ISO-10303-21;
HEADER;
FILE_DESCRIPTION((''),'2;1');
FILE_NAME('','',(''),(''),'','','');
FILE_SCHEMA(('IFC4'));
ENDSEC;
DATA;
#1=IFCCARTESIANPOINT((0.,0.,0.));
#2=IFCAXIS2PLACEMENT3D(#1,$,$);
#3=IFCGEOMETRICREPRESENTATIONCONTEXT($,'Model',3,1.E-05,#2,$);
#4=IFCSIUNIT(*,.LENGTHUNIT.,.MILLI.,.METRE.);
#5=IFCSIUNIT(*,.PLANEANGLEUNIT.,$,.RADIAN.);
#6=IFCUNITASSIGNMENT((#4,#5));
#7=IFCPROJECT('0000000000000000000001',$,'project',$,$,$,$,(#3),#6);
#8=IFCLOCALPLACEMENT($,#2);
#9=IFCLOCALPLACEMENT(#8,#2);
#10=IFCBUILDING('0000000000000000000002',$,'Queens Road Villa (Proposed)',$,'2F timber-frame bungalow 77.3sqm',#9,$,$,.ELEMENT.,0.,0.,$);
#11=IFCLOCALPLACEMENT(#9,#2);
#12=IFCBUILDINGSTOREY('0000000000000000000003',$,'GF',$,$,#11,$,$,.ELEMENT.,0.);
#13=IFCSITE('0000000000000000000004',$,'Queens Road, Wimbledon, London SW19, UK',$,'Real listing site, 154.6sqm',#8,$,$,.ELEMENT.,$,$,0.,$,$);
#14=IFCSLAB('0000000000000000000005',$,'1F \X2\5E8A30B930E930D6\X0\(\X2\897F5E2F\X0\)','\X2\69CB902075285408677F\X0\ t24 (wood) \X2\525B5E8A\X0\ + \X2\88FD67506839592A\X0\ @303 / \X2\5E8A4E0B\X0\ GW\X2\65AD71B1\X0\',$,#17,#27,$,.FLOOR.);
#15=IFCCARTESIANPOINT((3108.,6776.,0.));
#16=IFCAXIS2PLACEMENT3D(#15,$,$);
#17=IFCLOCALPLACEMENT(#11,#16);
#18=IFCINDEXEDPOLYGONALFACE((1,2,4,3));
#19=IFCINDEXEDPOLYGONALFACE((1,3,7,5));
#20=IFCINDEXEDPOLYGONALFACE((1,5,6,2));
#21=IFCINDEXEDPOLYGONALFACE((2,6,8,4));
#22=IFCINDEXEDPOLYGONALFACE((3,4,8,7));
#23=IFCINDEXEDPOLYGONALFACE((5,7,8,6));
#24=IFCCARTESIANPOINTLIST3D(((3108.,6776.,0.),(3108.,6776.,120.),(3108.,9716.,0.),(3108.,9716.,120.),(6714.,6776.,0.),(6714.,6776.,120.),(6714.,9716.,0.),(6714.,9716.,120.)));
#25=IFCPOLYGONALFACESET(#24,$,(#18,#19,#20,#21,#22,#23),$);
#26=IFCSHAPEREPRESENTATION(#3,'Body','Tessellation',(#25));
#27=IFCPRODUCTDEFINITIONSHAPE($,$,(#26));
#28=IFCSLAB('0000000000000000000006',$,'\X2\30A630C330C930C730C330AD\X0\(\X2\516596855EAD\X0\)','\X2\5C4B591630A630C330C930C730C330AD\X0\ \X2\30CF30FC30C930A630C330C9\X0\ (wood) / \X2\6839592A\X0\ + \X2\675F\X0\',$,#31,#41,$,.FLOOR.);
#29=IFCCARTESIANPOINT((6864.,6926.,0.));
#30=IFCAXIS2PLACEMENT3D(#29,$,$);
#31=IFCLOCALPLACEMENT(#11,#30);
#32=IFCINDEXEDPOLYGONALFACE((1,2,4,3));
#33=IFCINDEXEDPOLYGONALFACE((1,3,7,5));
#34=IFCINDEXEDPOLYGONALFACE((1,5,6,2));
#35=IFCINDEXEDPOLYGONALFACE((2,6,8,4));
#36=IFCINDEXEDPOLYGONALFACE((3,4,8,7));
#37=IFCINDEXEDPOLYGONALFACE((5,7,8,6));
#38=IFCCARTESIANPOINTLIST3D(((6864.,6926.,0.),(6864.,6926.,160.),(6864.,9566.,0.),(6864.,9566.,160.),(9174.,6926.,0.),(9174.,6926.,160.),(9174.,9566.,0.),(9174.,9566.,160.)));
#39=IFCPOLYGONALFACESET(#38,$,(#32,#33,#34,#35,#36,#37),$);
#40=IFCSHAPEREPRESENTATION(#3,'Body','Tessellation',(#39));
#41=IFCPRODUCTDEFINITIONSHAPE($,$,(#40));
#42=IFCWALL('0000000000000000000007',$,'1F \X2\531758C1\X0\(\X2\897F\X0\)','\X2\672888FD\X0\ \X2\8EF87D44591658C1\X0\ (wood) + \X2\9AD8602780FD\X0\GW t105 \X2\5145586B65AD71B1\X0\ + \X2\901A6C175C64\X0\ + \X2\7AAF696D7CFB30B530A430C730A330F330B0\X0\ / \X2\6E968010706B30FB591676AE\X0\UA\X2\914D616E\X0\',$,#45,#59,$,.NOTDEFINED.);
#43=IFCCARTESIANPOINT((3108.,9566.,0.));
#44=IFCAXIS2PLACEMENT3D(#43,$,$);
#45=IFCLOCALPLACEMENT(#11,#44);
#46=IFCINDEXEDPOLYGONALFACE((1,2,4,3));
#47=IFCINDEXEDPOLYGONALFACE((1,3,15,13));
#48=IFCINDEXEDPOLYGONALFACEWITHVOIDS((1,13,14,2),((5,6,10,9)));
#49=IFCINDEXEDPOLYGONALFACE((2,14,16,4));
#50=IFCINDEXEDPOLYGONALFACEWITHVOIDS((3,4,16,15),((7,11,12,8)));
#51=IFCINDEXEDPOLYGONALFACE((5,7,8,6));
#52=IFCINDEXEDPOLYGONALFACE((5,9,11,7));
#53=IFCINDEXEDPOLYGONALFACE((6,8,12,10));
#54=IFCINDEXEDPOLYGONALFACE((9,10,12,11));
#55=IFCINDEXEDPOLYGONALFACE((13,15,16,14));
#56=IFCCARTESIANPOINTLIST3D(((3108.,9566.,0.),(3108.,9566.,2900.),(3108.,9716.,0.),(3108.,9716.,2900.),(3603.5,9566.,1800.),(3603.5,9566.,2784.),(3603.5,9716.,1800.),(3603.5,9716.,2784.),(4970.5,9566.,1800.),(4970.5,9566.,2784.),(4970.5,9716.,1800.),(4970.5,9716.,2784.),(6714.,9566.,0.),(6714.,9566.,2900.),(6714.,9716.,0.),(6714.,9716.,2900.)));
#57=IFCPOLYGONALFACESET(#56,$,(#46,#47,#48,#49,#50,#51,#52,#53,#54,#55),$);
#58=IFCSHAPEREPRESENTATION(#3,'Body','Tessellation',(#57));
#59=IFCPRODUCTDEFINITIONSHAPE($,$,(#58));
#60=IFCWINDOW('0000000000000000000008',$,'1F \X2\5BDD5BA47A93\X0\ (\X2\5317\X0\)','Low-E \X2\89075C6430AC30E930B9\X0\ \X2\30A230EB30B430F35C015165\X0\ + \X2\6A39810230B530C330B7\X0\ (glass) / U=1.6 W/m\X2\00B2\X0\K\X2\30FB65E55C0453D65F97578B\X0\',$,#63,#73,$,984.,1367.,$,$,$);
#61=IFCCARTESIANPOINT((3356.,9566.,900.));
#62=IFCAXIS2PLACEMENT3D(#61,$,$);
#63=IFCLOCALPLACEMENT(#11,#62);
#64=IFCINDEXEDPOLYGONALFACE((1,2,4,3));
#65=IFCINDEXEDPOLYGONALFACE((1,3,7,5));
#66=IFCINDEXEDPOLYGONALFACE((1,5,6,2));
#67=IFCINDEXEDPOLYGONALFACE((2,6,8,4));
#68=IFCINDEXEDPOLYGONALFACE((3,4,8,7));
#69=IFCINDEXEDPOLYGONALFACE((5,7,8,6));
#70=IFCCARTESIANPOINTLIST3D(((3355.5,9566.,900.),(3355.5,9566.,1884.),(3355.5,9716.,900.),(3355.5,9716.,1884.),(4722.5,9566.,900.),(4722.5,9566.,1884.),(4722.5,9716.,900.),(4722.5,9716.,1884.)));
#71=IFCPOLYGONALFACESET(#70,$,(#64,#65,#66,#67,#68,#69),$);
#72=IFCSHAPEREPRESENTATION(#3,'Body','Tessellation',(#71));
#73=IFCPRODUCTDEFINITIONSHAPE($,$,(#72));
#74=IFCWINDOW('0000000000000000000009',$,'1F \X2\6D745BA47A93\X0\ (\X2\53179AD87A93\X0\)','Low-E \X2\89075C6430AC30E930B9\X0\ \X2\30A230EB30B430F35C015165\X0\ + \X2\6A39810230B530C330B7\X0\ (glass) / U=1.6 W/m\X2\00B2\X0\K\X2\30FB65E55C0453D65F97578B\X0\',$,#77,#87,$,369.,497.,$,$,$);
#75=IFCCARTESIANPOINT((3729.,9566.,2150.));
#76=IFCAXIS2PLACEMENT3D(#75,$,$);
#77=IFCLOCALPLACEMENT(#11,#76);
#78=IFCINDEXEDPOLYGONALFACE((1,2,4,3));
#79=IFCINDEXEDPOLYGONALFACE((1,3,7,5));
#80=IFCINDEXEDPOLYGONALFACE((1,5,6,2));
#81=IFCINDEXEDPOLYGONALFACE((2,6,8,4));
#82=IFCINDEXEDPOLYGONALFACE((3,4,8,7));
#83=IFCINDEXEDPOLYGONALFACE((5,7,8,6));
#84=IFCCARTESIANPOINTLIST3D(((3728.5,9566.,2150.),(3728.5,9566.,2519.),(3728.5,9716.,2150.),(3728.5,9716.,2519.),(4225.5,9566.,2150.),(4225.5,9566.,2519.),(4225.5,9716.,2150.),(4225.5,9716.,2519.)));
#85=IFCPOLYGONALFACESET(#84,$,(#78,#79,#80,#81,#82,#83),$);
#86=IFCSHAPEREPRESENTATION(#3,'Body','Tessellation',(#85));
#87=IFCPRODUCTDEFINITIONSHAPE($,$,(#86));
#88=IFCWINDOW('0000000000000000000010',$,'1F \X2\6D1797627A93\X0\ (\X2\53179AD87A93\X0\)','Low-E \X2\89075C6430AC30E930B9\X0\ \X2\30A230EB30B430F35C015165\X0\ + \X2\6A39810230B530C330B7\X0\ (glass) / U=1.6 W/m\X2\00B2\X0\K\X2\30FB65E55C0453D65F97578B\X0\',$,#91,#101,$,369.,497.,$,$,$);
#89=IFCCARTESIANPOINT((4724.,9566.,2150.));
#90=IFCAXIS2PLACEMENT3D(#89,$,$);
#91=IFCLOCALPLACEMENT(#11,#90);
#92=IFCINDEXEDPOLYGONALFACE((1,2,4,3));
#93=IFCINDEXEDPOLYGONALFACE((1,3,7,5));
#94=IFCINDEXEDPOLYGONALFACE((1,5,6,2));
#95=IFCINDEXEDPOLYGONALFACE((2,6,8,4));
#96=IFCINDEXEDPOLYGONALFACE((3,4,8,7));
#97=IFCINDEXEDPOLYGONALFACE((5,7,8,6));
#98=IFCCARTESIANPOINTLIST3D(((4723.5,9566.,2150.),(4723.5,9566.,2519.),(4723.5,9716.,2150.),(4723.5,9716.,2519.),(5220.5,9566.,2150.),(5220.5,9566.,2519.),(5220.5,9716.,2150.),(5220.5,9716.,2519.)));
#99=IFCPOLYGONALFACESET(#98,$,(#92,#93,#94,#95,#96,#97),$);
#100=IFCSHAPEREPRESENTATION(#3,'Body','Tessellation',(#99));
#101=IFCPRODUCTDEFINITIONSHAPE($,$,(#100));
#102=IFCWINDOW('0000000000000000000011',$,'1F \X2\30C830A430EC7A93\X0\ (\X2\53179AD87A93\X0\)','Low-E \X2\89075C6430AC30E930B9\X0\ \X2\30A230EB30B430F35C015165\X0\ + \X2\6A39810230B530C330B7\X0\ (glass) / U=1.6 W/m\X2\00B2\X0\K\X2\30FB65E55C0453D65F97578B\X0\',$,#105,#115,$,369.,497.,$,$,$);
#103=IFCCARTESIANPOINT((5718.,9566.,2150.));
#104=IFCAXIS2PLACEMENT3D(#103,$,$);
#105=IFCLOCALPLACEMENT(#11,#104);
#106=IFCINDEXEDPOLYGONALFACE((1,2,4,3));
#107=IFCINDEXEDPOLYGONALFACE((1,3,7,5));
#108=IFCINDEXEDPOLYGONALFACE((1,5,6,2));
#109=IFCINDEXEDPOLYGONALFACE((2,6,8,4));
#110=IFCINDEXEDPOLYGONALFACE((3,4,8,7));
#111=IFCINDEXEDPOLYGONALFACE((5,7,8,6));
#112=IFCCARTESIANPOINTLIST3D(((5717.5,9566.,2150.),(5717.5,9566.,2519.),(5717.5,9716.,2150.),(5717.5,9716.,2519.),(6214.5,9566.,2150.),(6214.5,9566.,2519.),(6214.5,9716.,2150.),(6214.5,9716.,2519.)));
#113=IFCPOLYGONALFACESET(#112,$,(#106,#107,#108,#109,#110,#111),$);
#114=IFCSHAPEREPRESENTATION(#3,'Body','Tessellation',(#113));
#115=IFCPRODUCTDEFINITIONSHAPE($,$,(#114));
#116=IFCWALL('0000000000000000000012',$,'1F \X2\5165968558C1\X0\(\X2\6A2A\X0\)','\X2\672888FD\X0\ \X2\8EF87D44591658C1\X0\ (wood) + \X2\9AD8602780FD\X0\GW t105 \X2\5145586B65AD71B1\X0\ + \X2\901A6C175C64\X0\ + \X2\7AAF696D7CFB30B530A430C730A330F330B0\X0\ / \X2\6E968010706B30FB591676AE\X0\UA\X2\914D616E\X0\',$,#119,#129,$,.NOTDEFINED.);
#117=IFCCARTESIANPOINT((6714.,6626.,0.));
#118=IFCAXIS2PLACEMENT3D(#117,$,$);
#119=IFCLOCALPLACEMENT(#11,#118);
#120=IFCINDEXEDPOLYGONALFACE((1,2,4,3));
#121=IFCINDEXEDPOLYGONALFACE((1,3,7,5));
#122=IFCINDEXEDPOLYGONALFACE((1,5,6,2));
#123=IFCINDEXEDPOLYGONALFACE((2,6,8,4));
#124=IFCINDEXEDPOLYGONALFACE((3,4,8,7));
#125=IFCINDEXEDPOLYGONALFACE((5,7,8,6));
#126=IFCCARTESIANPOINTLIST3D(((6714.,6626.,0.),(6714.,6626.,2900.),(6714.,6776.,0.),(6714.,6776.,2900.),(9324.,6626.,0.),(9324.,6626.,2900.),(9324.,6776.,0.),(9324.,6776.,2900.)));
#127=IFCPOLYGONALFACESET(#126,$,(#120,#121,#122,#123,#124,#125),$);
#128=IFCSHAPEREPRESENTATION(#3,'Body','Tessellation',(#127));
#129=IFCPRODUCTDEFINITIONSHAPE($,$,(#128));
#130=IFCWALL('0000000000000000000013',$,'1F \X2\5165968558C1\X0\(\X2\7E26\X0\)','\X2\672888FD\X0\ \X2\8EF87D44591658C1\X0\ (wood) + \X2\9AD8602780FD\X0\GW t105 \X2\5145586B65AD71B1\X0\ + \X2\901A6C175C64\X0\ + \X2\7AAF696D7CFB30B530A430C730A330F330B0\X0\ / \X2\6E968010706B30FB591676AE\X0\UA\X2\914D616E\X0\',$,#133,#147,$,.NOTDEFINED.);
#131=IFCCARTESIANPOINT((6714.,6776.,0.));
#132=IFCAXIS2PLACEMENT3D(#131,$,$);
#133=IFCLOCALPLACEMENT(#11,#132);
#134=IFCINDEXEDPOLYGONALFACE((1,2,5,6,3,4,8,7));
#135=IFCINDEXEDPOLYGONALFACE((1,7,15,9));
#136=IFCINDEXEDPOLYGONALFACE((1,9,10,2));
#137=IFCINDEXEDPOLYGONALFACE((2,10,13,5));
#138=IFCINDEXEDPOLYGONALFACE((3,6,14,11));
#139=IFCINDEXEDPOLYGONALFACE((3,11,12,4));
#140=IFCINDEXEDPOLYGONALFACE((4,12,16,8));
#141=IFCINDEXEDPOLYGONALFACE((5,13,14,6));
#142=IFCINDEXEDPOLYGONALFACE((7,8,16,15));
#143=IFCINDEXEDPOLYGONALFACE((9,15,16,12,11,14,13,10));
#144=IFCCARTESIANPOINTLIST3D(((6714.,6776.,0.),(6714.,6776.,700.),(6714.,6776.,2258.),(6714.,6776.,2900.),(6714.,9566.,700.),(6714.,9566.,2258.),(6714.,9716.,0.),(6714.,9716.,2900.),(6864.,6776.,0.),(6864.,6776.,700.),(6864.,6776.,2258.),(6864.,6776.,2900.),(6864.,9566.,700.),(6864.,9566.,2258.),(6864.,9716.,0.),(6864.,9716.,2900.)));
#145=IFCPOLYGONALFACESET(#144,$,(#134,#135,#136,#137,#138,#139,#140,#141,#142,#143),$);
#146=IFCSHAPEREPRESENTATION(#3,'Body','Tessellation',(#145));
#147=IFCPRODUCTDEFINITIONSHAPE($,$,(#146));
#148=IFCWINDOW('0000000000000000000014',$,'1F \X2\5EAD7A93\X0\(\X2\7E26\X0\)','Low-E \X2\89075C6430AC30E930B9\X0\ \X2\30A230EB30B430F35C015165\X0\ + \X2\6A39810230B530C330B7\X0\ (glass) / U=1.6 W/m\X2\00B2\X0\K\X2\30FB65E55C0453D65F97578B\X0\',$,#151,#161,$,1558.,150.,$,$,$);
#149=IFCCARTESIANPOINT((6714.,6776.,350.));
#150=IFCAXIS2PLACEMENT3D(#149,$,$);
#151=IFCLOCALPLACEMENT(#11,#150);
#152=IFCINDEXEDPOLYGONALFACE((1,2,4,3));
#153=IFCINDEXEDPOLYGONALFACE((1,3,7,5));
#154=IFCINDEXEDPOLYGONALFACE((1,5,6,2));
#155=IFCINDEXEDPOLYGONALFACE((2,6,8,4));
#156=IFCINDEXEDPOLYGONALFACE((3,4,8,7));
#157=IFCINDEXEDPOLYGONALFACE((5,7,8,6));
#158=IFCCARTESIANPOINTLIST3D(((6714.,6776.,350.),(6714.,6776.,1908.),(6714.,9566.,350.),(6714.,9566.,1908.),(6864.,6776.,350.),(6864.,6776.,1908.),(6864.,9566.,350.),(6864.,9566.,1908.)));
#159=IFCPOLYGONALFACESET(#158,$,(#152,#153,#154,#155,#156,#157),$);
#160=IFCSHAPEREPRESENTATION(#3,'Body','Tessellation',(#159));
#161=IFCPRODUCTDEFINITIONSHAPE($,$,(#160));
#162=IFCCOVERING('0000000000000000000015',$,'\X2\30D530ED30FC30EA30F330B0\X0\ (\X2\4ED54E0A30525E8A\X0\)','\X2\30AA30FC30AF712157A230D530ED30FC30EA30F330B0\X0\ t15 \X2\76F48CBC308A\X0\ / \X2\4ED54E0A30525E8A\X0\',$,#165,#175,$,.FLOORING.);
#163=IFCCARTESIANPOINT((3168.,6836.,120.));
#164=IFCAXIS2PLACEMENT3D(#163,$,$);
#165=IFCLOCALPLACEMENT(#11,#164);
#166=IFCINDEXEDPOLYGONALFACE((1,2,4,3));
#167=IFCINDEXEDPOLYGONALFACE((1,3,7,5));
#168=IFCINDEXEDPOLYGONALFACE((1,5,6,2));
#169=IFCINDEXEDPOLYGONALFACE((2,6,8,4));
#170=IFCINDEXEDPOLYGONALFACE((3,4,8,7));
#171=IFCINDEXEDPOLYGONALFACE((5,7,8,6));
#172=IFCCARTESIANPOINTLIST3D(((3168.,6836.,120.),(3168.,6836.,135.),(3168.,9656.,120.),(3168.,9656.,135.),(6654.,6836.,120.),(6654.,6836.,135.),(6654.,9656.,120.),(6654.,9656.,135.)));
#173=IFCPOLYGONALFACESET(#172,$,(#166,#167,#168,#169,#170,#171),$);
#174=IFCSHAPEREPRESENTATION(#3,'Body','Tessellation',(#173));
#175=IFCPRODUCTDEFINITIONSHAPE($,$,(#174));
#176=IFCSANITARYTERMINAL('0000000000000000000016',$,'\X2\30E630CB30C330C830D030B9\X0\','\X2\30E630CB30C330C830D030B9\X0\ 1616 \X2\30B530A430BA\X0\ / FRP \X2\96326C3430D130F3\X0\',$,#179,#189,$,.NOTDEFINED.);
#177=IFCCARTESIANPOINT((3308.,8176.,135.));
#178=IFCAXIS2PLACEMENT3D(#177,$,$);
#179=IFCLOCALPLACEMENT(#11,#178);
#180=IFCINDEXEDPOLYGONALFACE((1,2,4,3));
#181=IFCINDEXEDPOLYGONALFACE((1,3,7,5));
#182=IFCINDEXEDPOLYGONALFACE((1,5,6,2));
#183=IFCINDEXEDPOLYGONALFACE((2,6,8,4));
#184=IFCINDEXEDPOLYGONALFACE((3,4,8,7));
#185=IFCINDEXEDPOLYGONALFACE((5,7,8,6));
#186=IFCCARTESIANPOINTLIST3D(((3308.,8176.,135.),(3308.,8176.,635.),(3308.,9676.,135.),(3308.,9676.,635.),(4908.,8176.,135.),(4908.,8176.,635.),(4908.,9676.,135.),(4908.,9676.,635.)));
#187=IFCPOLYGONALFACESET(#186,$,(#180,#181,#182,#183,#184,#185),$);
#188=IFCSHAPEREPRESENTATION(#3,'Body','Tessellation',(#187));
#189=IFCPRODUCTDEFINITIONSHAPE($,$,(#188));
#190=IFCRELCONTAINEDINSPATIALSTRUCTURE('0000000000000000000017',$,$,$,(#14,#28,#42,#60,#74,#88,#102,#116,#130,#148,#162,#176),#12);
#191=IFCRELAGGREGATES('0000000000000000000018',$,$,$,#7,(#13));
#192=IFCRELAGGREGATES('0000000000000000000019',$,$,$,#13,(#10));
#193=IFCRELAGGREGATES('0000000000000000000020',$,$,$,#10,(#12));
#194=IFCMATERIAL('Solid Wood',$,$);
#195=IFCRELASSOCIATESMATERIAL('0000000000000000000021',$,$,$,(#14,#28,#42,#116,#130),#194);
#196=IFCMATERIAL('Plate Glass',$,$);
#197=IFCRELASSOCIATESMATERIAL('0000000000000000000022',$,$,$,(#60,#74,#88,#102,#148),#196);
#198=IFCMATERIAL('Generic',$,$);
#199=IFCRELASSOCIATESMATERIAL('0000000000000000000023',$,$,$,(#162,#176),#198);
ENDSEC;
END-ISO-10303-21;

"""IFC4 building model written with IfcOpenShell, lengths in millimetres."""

from ifc_helpers import new_model, si_unit, frame, frame_2d, origin, place, context, project, spatial, rectangle, extrude, material, element, fill, save


model = new_model("IFC4")

# Units and contexts
model_context = context("Model", 3, precision=1e-05, world=origin())
ifc_project = project(units=[si_unit("LENGTHUNIT", "METRE", prefix="MILLI"), si_unit("PLANEANGLEUNIT", "RADIAN")], contexts=[model_context])

# Site, building, storey
site_placement = place(None, origin())
site = spatial("IfcSite", under=ifc_project, at=site_placement, Name="Queens Road, Wimbledon, London SW19, UK", ObjectType="Real listing site, 154.6sqm", CompositionType="ELEMENT", RefElevation=0.0)
building_placement = place(site_placement, origin())
building = spatial("IfcBuilding", under=site, at=building_placement, Name="Queens Road Villa (Proposed)", ObjectType="2F timber-frame bungalow 77.3sqm", CompositionType="ELEMENT", ElevationOfRefHeight=0.0, ElevationOfTerrain=0.0)
storey_placement = place(building_placement, origin())
storey = spatial("IfcBuildingStorey", under=building, at=storey_placement, Name="GF", CompositionType="ELEMENT", Elevation=0.0)

# Slabs
ifc_material_1 = material(Name="Solid Wood")
slab_1_placement = place(storey_placement, frame((3108.0, 6776.0, 0.0)))
element("IfcSlab", 1, at=slab_1_placement, inside=storey, material=ifc_material_1, Name="1F 床スラブ(西帯)", Description="構造用合板 t24 (wood) 剛床 + 製材根太 @303 / 床下 GW断熱", PredefinedType="FLOOR", context=model_context, shape_type="SweptSolid", body=[
    extrude(rectangle(XDim=3606.0, YDim=2940.0, at=frame_2d((1803.0, 1470.0))), frame((3108.0, 6776.0, 0.0)), (0.0, 0.0, 1.0), 120.0),
])
slab_2_placement = place(storey_placement, frame((6864.0, 6926.0, 0.0)))
element("IfcSlab", 2, at=slab_2_placement, inside=storey, material=ifc_material_1, Name="ウッドデッキ(入隅庭)", Description="屋外ウッドデッキ ハードウッド (wood) / 根太 + 束", PredefinedType="FLOOR", context=model_context, shape_type="SweptSolid", body=[
    extrude(rectangle(XDim=2310.0, YDim=2640.0, at=frame_2d((1155.0, 1320.0))), frame((6864.0, 6926.0, 0.0)), (0.0, 0.0, 1.0), 160.0),
])

# Wall, openings, windows
wall_1_placement = place(storey_placement, frame((3108.0, 9566.0, 0.0)))
wall_1 = element("IfcWall", 3, at=wall_1_placement, inside=storey, material=ifc_material_1, Name="1F 北壁(西)", Description="木製 軸組外壁 (wood) + 高性能GW t105 充填断熱 + 通気層 + 窯業系サイディング / 準耐火・外皮UA配慮", PredefinedType="NOTDEFINED", context=model_context, shape_type="SweptSolid", body=[
    extrude(rectangle(XDim=3606.0, YDim=150.0, at=frame_2d((1803.0, 75.0))), frame((3108.0, 9566.0, 0.0)), (0.0, 0.0, 1.0), 2900.0),
])
opening_1_placement = place(storey_placement, frame((3356.0, 9566.0, 900.0)))
opening_1 = element("IfcOpeningElement", 4, at=opening_1_placement, cuts=wall_1, PredefinedType="NOTDEFINED", context=model_context, shape_type="SweptSolid", body=[
    extrude(rectangle(XDim=1367.0, YDim=150.0, at=frame_2d((683.0, 75.0))), frame((3356.0, 9566.0, 900.0)), (0.0, 0.0, 1.0), 984.0),
])
opening_2_placement = place(storey_placement, frame((3729.0, 9566.0, 2150.0)))
opening_2 = element("IfcOpeningElement", 5, at=opening_2_placement, cuts=wall_1, PredefinedType="NOTDEFINED", context=model_context, shape_type="SweptSolid", body=[
    extrude(rectangle(XDim=497.0, YDim=150.0, at=frame_2d((248.0, 75.0))), frame((3729.0, 9566.0, 2150.0)), (0.0, 0.0, 1.0), 369.0),
])
opening_3_placement = place(storey_placement, frame((4724.0, 9566.0, 2150.0)))
opening_3 = element("IfcOpeningElement", 6, at=opening_3_placement, cuts=wall_1, PredefinedType="NOTDEFINED", context=model_context, shape_type="SweptSolid", body=[
    extrude(rectangle(XDim=497.0, YDim=150.0, at=frame_2d((248.0, 75.0))), frame((4724.0, 9566.0, 2150.0)), (0.0, 0.0, 1.0), 369.0),
])
opening_4_placement = place(storey_placement, frame((5718.0, 9566.0, 2150.0)))
opening_4 = element("IfcOpeningElement", 7, at=opening_4_placement, cuts=wall_1, PredefinedType="NOTDEFINED", context=model_context, shape_type="SweptSolid", body=[
    extrude(rectangle(XDim=497.0, YDim=150.0, at=frame_2d((248.0, 75.0))), frame((5718.0, 9566.0, 2150.0)), (0.0, 0.0, 1.0), 369.0),
])
ifc_material_2 = material(Name="Plate Glass")
window_1_placement = place(storey_placement, frame((3356.0, 9566.0, 900.0)))
window_1 = element("IfcWindow", 8, at=window_1_placement, inside=storey, material=ifc_material_2, Name="1F 寝室窓 (北)", Description="Low-E 複層ガラス アルゴン封入 + 樹脂サッシ (glass) / U=1.6 W/m²K・日射取得型", OverallHeight=984.0, OverallWidth=1367.0, context=model_context, shape_type="SweptSolid", body=[
    extrude(rectangle(XDim=1367.0, YDim=150.0, at=frame_2d((683.0, 75.0))), frame((3356.0, 9566.0, 900.0)), (0.0, 0.0, 1.0), 984.0),
])
fill(opening_1, window_1)
window_2_placement = place(storey_placement, frame((3729.0, 9566.0, 2150.0)))
window_2 = element("IfcWindow", 9, at=window_2_placement, inside=storey, material=ifc_material_2, Name="1F 浴室窓 (北高窓)", Description="Low-E 複層ガラス アルゴン封入 + 樹脂サッシ (glass) / U=1.6 W/m²K・日射取得型", OverallHeight=369.0, OverallWidth=497.0, context=model_context, shape_type="SweptSolid", body=[
    extrude(rectangle(XDim=497.0, YDim=150.0, at=frame_2d((248.0, 75.0))), frame((3729.0, 9566.0, 2150.0)), (0.0, 0.0, 1.0), 369.0),
])
fill(opening_2, window_2)
window_3_placement = place(storey_placement, frame((4724.0, 9566.0, 2150.0)))
window_3 = element("IfcWindow", 10, at=window_3_placement, inside=storey, material=ifc_material_2, Name="1F 洗面窓 (北高窓)", Description="Low-E 複層ガラス アルゴン封入 + 樹脂サッシ (glass) / U=1.6 W/m²K・日射取得型", OverallHeight=369.0, OverallWidth=497.0, context=model_context, shape_type="SweptSolid", body=[
    extrude(rectangle(XDim=497.0, YDim=150.0, at=frame_2d((248.0, 75.0))), frame((4724.0, 9566.0, 2150.0)), (0.0, 0.0, 1.0), 369.0),
])
fill(opening_3, window_3)
window_4_placement = place(storey_placement, frame((5718.0, 9566.0, 2150.0)))
window_4 = element("IfcWindow", 11, at=window_4_placement, inside=storey, material=ifc_material_2, Name="1F トイレ窓 (北高窓)", Description="Low-E 複層ガラス アルゴン封入 + 樹脂サッシ (glass) / U=1.6 W/m²K・日射取得型", OverallHeight=369.0, OverallWidth=497.0, context=model_context, shape_type="SweptSolid", body=[
    extrude(rectangle(XDim=497.0, YDim=150.0, at=frame_2d((248.0, 75.0))), frame((5718.0, 9566.0, 2150.0)), (0.0, 0.0, 1.0), 369.0),
])
fill(opening_4, window_4)

# Wall
wall_2_placement = place(storey_placement, frame((6714.0, 6626.0, 0.0)))
element("IfcWall", 12, at=wall_2_placement, inside=storey, material=ifc_material_1, Name="1F 入隅壁(横)", Description="木製 軸組外壁 (wood) + 高性能GW t105 充填断熱 + 通気層 + 窯業系サイディング / 準耐火・外皮UA配慮", PredefinedType="NOTDEFINED", context=model_context, shape_type="SweptSolid", body=[
    extrude(rectangle(XDim=2610.0, YDim=150.0, at=frame_2d((1305.0, 75.0))), frame((6714.0, 6626.0, 0.0)), (0.0, 0.0, 1.0), 2900.0),
])

# Wall, opening, window
wall_3_placement = place(storey_placement, frame((6714.0, 6776.0, 0.0)))
wall_3 = element("IfcWall", 13, at=wall_3_placement, inside=storey, material=ifc_material_1, Name="1F 入隅壁(縦)", Description="木製 軸組外壁 (wood) + 高性能GW t105 充填断熱 + 通気層 + 窯業系サイディング / 準耐火・外皮UA配慮", PredefinedType="NOTDEFINED", context=model_context, shape_type="SweptSolid", body=[
    extrude(rectangle(XDim=150.0, YDim=2940.0, at=frame_2d((75.0, 1470.0))), frame((6714.0, 6776.0, 0.0)), (0.0, 0.0, 1.0), 2900.0),
])
opening_5_placement = place(storey_placement, frame((6714.0, 6776.0, 350.0)))
opening_5 = element("IfcOpeningElement", 14, at=opening_5_placement, cuts=wall_3, PredefinedType="NOTDEFINED", context=model_context, shape_type="SweptSolid", body=[
    extrude(rectangle(XDim=150.0, YDim=2790.0, at=frame_2d((75.0, 1395.0))), frame((6714.0, 6776.0, 350.0)), (0.0, 0.0, 1.0), 1558.0),
])
window_5_placement = place(storey_placement, frame((6714.0, 6776.0, 350.0)))
window_5 = element("IfcWindow", 15, at=window_5_placement, inside=storey, material=ifc_material_2, Name="1F 庭窓(縦)", Description="Low-E 複層ガラス アルゴン封入 + 樹脂サッシ (glass) / U=1.6 W/m²K・日射取得型", OverallHeight=1558.0, OverallWidth=150.0, context=model_context, shape_type="SweptSolid", body=[
    extrude(rectangle(XDim=150.0, YDim=2790.0, at=frame_2d((75.0, 1395.0))), frame((6714.0, 6776.0, 350.0)), (0.0, 0.0, 1.0), 1558.0),
])
fill(opening_5, window_5)

# Covering
ifc_material_3 = material(Name="Generic")
covering_placement = place(storey_placement, frame((3168.0, 6836.0, 120.0)))
element("IfcCovering", 16, at=covering_placement, inside=storey, material=ifc_material_3, Name="フローリング (仕上げ床)", Description="オーク無垢フローリング t15 直貼り / 仕上げ床", PredefinedType="FLOORING", context=model_context, shape_type="SweptSolid", body=[
    extrude(rectangle(XDim=3486.0, YDim=2820.0, at=frame_2d((1743.0, 1410.0))), frame((3168.0, 6836.0, 120.0)), (0.0, 0.0, 1.0), 15.0),
])

# Sanitary terminal
sanitary_terminal_1_placement = place(storey_placement, frame((3308.0, 8176.0, 135.0)))
element("IfcSanitaryTerminal", 17, at=sanitary_terminal_1_placement, inside=storey, material=ifc_material_3, Name="ユニットバス", Description="ユニットバス 1616 サイズ / FRP 防水パン", PredefinedType="NOTDEFINED", context=model_context, shape_type="SweptSolid", body=[
    extrude(rectangle(XDim=1600.0, YDim=1500.0, at=frame_2d((800.0, 750.0))), frame((3308.0, 8176.0, 135.0)), (0.0, 0.0, 1.0), 500.0),
])

save(model, "model.ifc")
